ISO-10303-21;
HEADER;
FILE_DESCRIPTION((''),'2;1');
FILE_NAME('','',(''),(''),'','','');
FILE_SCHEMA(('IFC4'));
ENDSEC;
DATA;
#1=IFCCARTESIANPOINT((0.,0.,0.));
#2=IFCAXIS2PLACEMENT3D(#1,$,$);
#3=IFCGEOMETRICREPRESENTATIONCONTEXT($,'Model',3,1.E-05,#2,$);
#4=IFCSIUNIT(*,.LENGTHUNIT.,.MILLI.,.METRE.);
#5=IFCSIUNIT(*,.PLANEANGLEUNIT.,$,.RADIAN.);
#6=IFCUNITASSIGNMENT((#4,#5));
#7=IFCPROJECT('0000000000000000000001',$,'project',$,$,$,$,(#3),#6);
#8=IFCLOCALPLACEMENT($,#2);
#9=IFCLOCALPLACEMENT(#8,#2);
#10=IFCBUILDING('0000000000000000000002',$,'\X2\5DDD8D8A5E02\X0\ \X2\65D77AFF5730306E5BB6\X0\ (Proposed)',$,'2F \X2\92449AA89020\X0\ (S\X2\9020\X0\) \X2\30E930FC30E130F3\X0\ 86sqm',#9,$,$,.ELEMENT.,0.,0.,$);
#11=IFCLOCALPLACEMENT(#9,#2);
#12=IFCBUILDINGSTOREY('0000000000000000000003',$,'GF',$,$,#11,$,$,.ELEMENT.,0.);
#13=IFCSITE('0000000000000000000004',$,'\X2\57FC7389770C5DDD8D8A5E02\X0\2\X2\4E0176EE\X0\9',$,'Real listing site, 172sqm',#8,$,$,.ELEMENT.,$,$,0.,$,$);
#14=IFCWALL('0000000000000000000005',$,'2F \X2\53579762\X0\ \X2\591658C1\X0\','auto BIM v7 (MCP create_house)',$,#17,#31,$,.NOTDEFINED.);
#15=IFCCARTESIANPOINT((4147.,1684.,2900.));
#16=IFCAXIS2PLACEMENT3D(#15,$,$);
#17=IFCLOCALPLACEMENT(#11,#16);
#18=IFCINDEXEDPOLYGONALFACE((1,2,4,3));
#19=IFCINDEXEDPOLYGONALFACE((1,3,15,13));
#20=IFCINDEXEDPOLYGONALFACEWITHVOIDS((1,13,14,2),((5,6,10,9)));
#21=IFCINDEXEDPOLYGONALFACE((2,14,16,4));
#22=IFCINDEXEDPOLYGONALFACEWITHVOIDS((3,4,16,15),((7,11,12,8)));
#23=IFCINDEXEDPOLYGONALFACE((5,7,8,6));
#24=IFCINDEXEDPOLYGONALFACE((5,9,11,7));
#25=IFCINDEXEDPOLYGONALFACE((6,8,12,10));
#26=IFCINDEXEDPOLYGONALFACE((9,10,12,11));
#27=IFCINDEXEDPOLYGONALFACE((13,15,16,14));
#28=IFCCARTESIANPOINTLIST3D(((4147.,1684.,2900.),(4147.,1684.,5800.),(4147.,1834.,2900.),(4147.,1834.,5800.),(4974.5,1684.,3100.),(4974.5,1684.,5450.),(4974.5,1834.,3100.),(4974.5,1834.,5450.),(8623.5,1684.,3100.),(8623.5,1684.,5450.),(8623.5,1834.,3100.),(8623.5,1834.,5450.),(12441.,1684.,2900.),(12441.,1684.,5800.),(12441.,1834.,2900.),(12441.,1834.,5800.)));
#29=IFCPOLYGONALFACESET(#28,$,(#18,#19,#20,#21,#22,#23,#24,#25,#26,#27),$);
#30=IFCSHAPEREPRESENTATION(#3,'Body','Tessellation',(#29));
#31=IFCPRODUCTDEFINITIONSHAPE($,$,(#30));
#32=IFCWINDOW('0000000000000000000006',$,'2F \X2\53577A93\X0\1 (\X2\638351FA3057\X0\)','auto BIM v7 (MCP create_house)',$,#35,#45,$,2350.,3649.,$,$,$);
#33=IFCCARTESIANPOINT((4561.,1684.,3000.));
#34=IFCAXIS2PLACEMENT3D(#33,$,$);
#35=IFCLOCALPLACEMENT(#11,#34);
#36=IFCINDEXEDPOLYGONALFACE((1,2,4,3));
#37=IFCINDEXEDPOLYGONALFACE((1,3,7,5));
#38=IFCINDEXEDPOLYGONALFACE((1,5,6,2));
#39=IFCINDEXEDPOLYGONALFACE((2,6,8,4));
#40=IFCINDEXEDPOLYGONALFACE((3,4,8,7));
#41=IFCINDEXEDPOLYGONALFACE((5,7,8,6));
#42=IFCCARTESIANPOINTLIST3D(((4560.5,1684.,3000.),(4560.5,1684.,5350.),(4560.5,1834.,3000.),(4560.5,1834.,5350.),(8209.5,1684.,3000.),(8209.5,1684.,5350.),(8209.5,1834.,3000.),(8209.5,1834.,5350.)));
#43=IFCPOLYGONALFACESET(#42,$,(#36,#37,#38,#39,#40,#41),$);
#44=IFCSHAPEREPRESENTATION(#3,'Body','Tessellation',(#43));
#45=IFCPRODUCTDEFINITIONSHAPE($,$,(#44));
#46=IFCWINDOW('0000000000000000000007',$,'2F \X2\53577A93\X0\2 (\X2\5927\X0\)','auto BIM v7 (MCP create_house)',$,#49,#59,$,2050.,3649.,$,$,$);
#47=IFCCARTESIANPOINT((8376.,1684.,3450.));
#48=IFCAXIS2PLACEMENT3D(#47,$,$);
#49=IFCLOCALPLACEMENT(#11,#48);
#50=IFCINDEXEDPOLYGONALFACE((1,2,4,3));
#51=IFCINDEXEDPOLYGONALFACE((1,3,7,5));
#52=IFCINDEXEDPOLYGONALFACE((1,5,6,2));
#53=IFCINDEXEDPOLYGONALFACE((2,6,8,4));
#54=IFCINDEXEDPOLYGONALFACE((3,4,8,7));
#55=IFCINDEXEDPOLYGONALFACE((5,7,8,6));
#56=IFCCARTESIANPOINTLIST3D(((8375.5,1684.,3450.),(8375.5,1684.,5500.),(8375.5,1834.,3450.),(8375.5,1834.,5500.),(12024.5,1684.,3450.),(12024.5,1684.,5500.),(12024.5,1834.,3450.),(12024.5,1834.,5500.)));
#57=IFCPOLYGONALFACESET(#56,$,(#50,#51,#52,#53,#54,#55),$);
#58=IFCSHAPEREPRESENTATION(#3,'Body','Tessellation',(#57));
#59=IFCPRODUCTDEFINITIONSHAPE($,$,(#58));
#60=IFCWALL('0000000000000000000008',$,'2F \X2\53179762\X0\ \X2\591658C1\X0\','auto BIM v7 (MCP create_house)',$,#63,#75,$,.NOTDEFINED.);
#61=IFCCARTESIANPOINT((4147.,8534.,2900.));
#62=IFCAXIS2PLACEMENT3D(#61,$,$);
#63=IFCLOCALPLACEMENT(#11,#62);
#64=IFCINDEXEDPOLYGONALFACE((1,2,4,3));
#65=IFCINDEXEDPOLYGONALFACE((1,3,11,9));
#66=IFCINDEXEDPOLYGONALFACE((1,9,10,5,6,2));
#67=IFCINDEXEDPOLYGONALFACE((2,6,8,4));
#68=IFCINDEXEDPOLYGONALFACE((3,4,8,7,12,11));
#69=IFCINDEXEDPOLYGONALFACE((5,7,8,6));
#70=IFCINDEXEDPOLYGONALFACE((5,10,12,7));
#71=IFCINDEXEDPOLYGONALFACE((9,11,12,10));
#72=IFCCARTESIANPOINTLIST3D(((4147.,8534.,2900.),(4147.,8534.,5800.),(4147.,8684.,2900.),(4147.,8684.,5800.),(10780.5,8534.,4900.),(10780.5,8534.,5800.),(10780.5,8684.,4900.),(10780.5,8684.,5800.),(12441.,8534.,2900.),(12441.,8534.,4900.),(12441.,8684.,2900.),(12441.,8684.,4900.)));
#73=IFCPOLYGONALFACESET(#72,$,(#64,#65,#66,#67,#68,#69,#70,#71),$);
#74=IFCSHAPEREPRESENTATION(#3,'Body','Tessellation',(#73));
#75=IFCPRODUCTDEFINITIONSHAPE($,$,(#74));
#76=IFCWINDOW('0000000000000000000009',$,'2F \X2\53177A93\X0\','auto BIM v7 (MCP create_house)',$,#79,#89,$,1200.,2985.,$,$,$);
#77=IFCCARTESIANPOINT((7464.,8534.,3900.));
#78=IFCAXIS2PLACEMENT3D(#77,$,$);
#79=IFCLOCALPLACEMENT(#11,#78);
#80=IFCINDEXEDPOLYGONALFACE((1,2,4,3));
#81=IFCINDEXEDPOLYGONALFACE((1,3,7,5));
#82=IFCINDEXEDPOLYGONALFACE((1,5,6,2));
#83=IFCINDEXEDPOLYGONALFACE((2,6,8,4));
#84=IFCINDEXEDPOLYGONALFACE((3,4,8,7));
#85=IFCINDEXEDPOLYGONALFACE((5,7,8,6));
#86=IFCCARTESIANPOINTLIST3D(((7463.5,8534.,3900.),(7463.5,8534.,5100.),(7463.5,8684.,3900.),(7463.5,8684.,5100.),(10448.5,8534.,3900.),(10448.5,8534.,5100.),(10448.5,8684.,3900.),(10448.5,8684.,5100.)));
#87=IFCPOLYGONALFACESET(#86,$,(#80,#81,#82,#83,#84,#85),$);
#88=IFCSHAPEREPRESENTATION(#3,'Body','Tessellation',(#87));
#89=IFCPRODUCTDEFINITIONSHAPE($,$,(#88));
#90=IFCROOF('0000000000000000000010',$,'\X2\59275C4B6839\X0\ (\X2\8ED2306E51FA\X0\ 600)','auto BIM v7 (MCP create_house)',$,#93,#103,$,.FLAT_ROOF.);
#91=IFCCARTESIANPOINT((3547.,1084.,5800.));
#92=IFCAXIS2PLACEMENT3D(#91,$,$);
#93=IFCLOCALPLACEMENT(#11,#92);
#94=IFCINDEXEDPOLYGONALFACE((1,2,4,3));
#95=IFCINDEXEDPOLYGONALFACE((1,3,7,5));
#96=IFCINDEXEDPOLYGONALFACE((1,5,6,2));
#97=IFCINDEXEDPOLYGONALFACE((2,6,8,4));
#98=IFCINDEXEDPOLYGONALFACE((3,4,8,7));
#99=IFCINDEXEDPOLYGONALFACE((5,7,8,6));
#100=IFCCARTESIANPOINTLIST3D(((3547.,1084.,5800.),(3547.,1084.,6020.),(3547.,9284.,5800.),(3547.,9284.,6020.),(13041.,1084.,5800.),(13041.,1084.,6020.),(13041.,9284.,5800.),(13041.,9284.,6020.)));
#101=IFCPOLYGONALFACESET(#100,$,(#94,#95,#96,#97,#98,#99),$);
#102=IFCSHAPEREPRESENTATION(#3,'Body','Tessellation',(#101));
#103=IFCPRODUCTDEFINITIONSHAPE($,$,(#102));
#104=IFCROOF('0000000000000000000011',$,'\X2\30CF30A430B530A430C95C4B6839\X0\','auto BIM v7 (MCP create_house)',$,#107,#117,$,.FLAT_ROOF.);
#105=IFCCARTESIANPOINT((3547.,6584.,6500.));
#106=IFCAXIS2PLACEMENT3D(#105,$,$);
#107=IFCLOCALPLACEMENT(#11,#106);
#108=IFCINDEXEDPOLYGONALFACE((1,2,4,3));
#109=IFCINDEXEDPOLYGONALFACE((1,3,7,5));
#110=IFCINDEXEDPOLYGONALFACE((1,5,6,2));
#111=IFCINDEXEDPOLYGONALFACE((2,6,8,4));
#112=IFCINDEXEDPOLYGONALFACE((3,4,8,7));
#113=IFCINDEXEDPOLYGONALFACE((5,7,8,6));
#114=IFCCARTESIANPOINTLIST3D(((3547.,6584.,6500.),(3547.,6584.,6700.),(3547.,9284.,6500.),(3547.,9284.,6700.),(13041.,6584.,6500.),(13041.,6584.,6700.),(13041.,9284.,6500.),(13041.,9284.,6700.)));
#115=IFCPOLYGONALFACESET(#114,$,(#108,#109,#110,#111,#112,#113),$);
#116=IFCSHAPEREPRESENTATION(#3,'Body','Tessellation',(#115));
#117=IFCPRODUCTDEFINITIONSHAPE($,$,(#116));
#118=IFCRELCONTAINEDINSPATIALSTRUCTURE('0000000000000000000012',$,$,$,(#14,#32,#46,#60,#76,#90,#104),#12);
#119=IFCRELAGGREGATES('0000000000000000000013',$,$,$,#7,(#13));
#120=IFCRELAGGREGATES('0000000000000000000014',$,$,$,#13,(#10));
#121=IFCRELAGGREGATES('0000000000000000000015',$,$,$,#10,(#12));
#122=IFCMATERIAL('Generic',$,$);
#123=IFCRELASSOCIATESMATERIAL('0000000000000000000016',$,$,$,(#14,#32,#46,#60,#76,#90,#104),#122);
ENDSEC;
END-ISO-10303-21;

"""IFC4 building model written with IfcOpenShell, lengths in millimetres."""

from ifc_helpers import new_model, si_unit, frame, frame_2d, origin, place, context, project, spatial, rectangle, extrude, material, element, fill, save


model = new_model("IFC4")

# Units and contexts
model_context = context("Model", 3, precision=1e-05, world=origin())
ifc_project = project(units=[si_unit("LENGTHUNIT", "METRE", prefix="MILLI"), si_unit("PLANEANGLEUNIT", "RADIAN")], contexts=[model_context])

# Site, building, storey
site_placement = place(None, origin())
site = spatial("IfcSite", under=ifc_project, at=site_placement, Name="埼玉県川越市2丁目9", ObjectType="Real listing site, 172sqm", CompositionType="ELEMENT", RefElevation=0.0)
building_placement = place(site_placement, origin())
building = spatial("IfcBuilding", under=site, at=building_placement, Name="川越市 旗竿地の家 (Proposed)", ObjectType="2F 鉄骨造 (S造) ラーメン 86sqm", CompositionType="ELEMENT", ElevationOfRefHeight=0.0, ElevationOfTerrain=0.0)
storey_placement = place(building_placement, origin())
storey = spatial("IfcBuildingStorey", under=building, at=storey_placement, Name="GF", CompositionType="ELEMENT", Elevation=0.0)

# Shared definitions
ifc_material = material(Name="Generic")

# Wall, openings, windows
wall_1_placement = place(storey_placement, frame((4147.0, 1684.0, 2900.0)))
wall_1 = element("IfcWall", 1, at=wall_1_placement, inside=storey, material=ifc_material, Name="2F 南面 外壁", Description="auto BIM v7 (MCP create_house)", PredefinedType="NOTDEFINED", context=model_context, shape_type="SweptSolid", body=[
    extrude(rectangle(XDim=8294.0, YDim=150.0, at=frame_2d((4147.0, 75.0))), frame((4147.0, 1684.0, 2900.0)), (0.0, 0.0, 1.0), 2900.0),
])
opening_1_placement = place(storey_placement, frame((4561.0, 1684.0, 3000.0)))
opening_1 = element("IfcOpeningElement", 2, at=opening_1_placement, cuts=wall_1, PredefinedType="NOTDEFINED", context=model_context, shape_type="SweptSolid", body=[
    extrude(rectangle(XDim=3649.0, YDim=150.0, at=frame_2d((1824.0, 75.0))), frame((4561.0, 1684.0, 3000.0)), (0.0, 0.0, 1.0), 2350.0),
])
opening_2_placement = place(storey_placement, frame((8376.0, 1684.0, 3450.0)))
opening_2 = element("IfcOpeningElement", 3, at=opening_2_placement, cuts=wall_1, PredefinedType="NOTDEFINED", context=model_context, shape_type="SweptSolid", body=[
    extrude(rectangle(XDim=3649.0, YDim=150.0, at=frame_2d((1824.0, 75.0))), frame((8376.0, 1684.0, 3450.0)), (0.0, 0.0, 1.0), 2050.0),
])
window_1_placement = place(storey_placement, frame((4561.0, 1684.0, 3000.0)))
window_1 = element("IfcWindow", 4, at=window_1_placement, inside=storey, material=ifc_material, Name="2F 南窓1 (掃出し)", Description="auto BIM v7 (MCP create_house)", OverallHeight=2350.0, OverallWidth=3649.0, context=model_context, shape_type="SweptSolid", body=[
    extrude(rectangle(XDim=3649.0, YDim=150.0, at=frame_2d((1824.0, 75.0))), frame((4561.0, 1684.0, 3000.0)), (0.0, 0.0, 1.0), 2350.0),
])
fill(opening_1, window_1)
window_2_placement = place(storey_placement, frame((8376.0, 1684.0, 3450.0)))
window_2 = element("IfcWindow", 5, at=window_2_placement, inside=storey, material=ifc_material, Name="2F 南窓2 (大)", Description="auto BIM v7 (MCP create_house)", OverallHeight=2050.0, OverallWidth=3649.0, context=model_context, shape_type="SweptSolid", body=[
    extrude(rectangle(XDim=3649.0, YDim=150.0, at=frame_2d((1824.0, 75.0))), frame((8376.0, 1684.0, 3450.0)), (0.0, 0.0, 1.0), 2050.0),
])
fill(opening_2, window_2)

# Wall, opening, window
wall_2_placement = place(storey_placement, frame((4147.0, 8534.0, 2900.0)))
wall_2 = element("IfcWall", 6, at=wall_2_placement, inside=storey, material=ifc_material, Name="2F 北面 外壁", Description="auto BIM v7 (MCP create_house)", PredefinedType="NOTDEFINED", context=model_context, shape_type="SweptSolid", body=[
    extrude(rectangle(XDim=8294.0, YDim=150.0, at=frame_2d((4147.0, 75.0))), frame((4147.0, 8534.0, 2900.0)), (0.0, 0.0, 1.0), 2900.0),
])
opening_3_placement = place(storey_placement, frame((7464.0, 8534.0, 3900.0)))
opening_3 = element("IfcOpeningElement", 7, at=opening_3_placement, cuts=wall_2, PredefinedType="NOTDEFINED", context=model_context, shape_type="SweptSolid", body=[
    extrude(rectangle(XDim=2985.0, YDim=150.0, at=frame_2d((1492.0, 75.0))), frame((7464.0, 8534.0, 3900.0)), (0.0, 0.0, 1.0), 1200.0),
])
window_3_placement = place(storey_placement, frame((7464.0, 8534.0, 3900.0)))
window_3 = element("IfcWindow", 8, at=window_3_placement, inside=storey, material=ifc_material, Name="2F 北窓", Description="auto BIM v7 (MCP create_house)", OverallHeight=1200.0, OverallWidth=2985.0, context=model_context, shape_type="SweptSolid", body=[
    extrude(rectangle(XDim=2985.0, YDim=150.0, at=frame_2d((1492.0, 75.0))), frame((7464.0, 8534.0, 3900.0)), (0.0, 0.0, 1.0), 1200.0),
])
fill(opening_3, window_3)

# Roofs
roof_1_placement = place(storey_placement, frame((3547.0, 1084.0, 5800.0)))
element("IfcRoof", 9, at=roof_1_placement, inside=storey, material=ifc_material, Name="大屋根 (軒の出 600)", Description="auto BIM v7 (MCP create_house)", PredefinedType="FLAT_ROOF", context=model_context, shape_type="SweptSolid", body=[
    extrude(rectangle(XDim=9494.0, YDim=8200.0, at=frame_2d((4747.0, 4100.0))), frame((3547.0, 1084.0, 5800.0)), (0.0, 0.0, 1.0), 220.0),
])
roof_2_placement = place(storey_placement, frame((3547.0, 6584.0, 6500.0)))
element("IfcRoof", 10, at=roof_2_placement, inside=storey, material=ifc_material, Name="ハイサイド屋根", Description="auto BIM v7 (MCP create_house)", PredefinedType="FLAT_ROOF", context=model_context, shape_type="SweptSolid", body=[
    extrude(rectangle(XDim=9494.0, YDim=2700.0, at=frame_2d((4747.0, 1350.0))), frame((3547.0, 6584.0, 6500.0)), (0.0, 0.0, 1.0), 200.0),
])

save(model, "model.ifc")
